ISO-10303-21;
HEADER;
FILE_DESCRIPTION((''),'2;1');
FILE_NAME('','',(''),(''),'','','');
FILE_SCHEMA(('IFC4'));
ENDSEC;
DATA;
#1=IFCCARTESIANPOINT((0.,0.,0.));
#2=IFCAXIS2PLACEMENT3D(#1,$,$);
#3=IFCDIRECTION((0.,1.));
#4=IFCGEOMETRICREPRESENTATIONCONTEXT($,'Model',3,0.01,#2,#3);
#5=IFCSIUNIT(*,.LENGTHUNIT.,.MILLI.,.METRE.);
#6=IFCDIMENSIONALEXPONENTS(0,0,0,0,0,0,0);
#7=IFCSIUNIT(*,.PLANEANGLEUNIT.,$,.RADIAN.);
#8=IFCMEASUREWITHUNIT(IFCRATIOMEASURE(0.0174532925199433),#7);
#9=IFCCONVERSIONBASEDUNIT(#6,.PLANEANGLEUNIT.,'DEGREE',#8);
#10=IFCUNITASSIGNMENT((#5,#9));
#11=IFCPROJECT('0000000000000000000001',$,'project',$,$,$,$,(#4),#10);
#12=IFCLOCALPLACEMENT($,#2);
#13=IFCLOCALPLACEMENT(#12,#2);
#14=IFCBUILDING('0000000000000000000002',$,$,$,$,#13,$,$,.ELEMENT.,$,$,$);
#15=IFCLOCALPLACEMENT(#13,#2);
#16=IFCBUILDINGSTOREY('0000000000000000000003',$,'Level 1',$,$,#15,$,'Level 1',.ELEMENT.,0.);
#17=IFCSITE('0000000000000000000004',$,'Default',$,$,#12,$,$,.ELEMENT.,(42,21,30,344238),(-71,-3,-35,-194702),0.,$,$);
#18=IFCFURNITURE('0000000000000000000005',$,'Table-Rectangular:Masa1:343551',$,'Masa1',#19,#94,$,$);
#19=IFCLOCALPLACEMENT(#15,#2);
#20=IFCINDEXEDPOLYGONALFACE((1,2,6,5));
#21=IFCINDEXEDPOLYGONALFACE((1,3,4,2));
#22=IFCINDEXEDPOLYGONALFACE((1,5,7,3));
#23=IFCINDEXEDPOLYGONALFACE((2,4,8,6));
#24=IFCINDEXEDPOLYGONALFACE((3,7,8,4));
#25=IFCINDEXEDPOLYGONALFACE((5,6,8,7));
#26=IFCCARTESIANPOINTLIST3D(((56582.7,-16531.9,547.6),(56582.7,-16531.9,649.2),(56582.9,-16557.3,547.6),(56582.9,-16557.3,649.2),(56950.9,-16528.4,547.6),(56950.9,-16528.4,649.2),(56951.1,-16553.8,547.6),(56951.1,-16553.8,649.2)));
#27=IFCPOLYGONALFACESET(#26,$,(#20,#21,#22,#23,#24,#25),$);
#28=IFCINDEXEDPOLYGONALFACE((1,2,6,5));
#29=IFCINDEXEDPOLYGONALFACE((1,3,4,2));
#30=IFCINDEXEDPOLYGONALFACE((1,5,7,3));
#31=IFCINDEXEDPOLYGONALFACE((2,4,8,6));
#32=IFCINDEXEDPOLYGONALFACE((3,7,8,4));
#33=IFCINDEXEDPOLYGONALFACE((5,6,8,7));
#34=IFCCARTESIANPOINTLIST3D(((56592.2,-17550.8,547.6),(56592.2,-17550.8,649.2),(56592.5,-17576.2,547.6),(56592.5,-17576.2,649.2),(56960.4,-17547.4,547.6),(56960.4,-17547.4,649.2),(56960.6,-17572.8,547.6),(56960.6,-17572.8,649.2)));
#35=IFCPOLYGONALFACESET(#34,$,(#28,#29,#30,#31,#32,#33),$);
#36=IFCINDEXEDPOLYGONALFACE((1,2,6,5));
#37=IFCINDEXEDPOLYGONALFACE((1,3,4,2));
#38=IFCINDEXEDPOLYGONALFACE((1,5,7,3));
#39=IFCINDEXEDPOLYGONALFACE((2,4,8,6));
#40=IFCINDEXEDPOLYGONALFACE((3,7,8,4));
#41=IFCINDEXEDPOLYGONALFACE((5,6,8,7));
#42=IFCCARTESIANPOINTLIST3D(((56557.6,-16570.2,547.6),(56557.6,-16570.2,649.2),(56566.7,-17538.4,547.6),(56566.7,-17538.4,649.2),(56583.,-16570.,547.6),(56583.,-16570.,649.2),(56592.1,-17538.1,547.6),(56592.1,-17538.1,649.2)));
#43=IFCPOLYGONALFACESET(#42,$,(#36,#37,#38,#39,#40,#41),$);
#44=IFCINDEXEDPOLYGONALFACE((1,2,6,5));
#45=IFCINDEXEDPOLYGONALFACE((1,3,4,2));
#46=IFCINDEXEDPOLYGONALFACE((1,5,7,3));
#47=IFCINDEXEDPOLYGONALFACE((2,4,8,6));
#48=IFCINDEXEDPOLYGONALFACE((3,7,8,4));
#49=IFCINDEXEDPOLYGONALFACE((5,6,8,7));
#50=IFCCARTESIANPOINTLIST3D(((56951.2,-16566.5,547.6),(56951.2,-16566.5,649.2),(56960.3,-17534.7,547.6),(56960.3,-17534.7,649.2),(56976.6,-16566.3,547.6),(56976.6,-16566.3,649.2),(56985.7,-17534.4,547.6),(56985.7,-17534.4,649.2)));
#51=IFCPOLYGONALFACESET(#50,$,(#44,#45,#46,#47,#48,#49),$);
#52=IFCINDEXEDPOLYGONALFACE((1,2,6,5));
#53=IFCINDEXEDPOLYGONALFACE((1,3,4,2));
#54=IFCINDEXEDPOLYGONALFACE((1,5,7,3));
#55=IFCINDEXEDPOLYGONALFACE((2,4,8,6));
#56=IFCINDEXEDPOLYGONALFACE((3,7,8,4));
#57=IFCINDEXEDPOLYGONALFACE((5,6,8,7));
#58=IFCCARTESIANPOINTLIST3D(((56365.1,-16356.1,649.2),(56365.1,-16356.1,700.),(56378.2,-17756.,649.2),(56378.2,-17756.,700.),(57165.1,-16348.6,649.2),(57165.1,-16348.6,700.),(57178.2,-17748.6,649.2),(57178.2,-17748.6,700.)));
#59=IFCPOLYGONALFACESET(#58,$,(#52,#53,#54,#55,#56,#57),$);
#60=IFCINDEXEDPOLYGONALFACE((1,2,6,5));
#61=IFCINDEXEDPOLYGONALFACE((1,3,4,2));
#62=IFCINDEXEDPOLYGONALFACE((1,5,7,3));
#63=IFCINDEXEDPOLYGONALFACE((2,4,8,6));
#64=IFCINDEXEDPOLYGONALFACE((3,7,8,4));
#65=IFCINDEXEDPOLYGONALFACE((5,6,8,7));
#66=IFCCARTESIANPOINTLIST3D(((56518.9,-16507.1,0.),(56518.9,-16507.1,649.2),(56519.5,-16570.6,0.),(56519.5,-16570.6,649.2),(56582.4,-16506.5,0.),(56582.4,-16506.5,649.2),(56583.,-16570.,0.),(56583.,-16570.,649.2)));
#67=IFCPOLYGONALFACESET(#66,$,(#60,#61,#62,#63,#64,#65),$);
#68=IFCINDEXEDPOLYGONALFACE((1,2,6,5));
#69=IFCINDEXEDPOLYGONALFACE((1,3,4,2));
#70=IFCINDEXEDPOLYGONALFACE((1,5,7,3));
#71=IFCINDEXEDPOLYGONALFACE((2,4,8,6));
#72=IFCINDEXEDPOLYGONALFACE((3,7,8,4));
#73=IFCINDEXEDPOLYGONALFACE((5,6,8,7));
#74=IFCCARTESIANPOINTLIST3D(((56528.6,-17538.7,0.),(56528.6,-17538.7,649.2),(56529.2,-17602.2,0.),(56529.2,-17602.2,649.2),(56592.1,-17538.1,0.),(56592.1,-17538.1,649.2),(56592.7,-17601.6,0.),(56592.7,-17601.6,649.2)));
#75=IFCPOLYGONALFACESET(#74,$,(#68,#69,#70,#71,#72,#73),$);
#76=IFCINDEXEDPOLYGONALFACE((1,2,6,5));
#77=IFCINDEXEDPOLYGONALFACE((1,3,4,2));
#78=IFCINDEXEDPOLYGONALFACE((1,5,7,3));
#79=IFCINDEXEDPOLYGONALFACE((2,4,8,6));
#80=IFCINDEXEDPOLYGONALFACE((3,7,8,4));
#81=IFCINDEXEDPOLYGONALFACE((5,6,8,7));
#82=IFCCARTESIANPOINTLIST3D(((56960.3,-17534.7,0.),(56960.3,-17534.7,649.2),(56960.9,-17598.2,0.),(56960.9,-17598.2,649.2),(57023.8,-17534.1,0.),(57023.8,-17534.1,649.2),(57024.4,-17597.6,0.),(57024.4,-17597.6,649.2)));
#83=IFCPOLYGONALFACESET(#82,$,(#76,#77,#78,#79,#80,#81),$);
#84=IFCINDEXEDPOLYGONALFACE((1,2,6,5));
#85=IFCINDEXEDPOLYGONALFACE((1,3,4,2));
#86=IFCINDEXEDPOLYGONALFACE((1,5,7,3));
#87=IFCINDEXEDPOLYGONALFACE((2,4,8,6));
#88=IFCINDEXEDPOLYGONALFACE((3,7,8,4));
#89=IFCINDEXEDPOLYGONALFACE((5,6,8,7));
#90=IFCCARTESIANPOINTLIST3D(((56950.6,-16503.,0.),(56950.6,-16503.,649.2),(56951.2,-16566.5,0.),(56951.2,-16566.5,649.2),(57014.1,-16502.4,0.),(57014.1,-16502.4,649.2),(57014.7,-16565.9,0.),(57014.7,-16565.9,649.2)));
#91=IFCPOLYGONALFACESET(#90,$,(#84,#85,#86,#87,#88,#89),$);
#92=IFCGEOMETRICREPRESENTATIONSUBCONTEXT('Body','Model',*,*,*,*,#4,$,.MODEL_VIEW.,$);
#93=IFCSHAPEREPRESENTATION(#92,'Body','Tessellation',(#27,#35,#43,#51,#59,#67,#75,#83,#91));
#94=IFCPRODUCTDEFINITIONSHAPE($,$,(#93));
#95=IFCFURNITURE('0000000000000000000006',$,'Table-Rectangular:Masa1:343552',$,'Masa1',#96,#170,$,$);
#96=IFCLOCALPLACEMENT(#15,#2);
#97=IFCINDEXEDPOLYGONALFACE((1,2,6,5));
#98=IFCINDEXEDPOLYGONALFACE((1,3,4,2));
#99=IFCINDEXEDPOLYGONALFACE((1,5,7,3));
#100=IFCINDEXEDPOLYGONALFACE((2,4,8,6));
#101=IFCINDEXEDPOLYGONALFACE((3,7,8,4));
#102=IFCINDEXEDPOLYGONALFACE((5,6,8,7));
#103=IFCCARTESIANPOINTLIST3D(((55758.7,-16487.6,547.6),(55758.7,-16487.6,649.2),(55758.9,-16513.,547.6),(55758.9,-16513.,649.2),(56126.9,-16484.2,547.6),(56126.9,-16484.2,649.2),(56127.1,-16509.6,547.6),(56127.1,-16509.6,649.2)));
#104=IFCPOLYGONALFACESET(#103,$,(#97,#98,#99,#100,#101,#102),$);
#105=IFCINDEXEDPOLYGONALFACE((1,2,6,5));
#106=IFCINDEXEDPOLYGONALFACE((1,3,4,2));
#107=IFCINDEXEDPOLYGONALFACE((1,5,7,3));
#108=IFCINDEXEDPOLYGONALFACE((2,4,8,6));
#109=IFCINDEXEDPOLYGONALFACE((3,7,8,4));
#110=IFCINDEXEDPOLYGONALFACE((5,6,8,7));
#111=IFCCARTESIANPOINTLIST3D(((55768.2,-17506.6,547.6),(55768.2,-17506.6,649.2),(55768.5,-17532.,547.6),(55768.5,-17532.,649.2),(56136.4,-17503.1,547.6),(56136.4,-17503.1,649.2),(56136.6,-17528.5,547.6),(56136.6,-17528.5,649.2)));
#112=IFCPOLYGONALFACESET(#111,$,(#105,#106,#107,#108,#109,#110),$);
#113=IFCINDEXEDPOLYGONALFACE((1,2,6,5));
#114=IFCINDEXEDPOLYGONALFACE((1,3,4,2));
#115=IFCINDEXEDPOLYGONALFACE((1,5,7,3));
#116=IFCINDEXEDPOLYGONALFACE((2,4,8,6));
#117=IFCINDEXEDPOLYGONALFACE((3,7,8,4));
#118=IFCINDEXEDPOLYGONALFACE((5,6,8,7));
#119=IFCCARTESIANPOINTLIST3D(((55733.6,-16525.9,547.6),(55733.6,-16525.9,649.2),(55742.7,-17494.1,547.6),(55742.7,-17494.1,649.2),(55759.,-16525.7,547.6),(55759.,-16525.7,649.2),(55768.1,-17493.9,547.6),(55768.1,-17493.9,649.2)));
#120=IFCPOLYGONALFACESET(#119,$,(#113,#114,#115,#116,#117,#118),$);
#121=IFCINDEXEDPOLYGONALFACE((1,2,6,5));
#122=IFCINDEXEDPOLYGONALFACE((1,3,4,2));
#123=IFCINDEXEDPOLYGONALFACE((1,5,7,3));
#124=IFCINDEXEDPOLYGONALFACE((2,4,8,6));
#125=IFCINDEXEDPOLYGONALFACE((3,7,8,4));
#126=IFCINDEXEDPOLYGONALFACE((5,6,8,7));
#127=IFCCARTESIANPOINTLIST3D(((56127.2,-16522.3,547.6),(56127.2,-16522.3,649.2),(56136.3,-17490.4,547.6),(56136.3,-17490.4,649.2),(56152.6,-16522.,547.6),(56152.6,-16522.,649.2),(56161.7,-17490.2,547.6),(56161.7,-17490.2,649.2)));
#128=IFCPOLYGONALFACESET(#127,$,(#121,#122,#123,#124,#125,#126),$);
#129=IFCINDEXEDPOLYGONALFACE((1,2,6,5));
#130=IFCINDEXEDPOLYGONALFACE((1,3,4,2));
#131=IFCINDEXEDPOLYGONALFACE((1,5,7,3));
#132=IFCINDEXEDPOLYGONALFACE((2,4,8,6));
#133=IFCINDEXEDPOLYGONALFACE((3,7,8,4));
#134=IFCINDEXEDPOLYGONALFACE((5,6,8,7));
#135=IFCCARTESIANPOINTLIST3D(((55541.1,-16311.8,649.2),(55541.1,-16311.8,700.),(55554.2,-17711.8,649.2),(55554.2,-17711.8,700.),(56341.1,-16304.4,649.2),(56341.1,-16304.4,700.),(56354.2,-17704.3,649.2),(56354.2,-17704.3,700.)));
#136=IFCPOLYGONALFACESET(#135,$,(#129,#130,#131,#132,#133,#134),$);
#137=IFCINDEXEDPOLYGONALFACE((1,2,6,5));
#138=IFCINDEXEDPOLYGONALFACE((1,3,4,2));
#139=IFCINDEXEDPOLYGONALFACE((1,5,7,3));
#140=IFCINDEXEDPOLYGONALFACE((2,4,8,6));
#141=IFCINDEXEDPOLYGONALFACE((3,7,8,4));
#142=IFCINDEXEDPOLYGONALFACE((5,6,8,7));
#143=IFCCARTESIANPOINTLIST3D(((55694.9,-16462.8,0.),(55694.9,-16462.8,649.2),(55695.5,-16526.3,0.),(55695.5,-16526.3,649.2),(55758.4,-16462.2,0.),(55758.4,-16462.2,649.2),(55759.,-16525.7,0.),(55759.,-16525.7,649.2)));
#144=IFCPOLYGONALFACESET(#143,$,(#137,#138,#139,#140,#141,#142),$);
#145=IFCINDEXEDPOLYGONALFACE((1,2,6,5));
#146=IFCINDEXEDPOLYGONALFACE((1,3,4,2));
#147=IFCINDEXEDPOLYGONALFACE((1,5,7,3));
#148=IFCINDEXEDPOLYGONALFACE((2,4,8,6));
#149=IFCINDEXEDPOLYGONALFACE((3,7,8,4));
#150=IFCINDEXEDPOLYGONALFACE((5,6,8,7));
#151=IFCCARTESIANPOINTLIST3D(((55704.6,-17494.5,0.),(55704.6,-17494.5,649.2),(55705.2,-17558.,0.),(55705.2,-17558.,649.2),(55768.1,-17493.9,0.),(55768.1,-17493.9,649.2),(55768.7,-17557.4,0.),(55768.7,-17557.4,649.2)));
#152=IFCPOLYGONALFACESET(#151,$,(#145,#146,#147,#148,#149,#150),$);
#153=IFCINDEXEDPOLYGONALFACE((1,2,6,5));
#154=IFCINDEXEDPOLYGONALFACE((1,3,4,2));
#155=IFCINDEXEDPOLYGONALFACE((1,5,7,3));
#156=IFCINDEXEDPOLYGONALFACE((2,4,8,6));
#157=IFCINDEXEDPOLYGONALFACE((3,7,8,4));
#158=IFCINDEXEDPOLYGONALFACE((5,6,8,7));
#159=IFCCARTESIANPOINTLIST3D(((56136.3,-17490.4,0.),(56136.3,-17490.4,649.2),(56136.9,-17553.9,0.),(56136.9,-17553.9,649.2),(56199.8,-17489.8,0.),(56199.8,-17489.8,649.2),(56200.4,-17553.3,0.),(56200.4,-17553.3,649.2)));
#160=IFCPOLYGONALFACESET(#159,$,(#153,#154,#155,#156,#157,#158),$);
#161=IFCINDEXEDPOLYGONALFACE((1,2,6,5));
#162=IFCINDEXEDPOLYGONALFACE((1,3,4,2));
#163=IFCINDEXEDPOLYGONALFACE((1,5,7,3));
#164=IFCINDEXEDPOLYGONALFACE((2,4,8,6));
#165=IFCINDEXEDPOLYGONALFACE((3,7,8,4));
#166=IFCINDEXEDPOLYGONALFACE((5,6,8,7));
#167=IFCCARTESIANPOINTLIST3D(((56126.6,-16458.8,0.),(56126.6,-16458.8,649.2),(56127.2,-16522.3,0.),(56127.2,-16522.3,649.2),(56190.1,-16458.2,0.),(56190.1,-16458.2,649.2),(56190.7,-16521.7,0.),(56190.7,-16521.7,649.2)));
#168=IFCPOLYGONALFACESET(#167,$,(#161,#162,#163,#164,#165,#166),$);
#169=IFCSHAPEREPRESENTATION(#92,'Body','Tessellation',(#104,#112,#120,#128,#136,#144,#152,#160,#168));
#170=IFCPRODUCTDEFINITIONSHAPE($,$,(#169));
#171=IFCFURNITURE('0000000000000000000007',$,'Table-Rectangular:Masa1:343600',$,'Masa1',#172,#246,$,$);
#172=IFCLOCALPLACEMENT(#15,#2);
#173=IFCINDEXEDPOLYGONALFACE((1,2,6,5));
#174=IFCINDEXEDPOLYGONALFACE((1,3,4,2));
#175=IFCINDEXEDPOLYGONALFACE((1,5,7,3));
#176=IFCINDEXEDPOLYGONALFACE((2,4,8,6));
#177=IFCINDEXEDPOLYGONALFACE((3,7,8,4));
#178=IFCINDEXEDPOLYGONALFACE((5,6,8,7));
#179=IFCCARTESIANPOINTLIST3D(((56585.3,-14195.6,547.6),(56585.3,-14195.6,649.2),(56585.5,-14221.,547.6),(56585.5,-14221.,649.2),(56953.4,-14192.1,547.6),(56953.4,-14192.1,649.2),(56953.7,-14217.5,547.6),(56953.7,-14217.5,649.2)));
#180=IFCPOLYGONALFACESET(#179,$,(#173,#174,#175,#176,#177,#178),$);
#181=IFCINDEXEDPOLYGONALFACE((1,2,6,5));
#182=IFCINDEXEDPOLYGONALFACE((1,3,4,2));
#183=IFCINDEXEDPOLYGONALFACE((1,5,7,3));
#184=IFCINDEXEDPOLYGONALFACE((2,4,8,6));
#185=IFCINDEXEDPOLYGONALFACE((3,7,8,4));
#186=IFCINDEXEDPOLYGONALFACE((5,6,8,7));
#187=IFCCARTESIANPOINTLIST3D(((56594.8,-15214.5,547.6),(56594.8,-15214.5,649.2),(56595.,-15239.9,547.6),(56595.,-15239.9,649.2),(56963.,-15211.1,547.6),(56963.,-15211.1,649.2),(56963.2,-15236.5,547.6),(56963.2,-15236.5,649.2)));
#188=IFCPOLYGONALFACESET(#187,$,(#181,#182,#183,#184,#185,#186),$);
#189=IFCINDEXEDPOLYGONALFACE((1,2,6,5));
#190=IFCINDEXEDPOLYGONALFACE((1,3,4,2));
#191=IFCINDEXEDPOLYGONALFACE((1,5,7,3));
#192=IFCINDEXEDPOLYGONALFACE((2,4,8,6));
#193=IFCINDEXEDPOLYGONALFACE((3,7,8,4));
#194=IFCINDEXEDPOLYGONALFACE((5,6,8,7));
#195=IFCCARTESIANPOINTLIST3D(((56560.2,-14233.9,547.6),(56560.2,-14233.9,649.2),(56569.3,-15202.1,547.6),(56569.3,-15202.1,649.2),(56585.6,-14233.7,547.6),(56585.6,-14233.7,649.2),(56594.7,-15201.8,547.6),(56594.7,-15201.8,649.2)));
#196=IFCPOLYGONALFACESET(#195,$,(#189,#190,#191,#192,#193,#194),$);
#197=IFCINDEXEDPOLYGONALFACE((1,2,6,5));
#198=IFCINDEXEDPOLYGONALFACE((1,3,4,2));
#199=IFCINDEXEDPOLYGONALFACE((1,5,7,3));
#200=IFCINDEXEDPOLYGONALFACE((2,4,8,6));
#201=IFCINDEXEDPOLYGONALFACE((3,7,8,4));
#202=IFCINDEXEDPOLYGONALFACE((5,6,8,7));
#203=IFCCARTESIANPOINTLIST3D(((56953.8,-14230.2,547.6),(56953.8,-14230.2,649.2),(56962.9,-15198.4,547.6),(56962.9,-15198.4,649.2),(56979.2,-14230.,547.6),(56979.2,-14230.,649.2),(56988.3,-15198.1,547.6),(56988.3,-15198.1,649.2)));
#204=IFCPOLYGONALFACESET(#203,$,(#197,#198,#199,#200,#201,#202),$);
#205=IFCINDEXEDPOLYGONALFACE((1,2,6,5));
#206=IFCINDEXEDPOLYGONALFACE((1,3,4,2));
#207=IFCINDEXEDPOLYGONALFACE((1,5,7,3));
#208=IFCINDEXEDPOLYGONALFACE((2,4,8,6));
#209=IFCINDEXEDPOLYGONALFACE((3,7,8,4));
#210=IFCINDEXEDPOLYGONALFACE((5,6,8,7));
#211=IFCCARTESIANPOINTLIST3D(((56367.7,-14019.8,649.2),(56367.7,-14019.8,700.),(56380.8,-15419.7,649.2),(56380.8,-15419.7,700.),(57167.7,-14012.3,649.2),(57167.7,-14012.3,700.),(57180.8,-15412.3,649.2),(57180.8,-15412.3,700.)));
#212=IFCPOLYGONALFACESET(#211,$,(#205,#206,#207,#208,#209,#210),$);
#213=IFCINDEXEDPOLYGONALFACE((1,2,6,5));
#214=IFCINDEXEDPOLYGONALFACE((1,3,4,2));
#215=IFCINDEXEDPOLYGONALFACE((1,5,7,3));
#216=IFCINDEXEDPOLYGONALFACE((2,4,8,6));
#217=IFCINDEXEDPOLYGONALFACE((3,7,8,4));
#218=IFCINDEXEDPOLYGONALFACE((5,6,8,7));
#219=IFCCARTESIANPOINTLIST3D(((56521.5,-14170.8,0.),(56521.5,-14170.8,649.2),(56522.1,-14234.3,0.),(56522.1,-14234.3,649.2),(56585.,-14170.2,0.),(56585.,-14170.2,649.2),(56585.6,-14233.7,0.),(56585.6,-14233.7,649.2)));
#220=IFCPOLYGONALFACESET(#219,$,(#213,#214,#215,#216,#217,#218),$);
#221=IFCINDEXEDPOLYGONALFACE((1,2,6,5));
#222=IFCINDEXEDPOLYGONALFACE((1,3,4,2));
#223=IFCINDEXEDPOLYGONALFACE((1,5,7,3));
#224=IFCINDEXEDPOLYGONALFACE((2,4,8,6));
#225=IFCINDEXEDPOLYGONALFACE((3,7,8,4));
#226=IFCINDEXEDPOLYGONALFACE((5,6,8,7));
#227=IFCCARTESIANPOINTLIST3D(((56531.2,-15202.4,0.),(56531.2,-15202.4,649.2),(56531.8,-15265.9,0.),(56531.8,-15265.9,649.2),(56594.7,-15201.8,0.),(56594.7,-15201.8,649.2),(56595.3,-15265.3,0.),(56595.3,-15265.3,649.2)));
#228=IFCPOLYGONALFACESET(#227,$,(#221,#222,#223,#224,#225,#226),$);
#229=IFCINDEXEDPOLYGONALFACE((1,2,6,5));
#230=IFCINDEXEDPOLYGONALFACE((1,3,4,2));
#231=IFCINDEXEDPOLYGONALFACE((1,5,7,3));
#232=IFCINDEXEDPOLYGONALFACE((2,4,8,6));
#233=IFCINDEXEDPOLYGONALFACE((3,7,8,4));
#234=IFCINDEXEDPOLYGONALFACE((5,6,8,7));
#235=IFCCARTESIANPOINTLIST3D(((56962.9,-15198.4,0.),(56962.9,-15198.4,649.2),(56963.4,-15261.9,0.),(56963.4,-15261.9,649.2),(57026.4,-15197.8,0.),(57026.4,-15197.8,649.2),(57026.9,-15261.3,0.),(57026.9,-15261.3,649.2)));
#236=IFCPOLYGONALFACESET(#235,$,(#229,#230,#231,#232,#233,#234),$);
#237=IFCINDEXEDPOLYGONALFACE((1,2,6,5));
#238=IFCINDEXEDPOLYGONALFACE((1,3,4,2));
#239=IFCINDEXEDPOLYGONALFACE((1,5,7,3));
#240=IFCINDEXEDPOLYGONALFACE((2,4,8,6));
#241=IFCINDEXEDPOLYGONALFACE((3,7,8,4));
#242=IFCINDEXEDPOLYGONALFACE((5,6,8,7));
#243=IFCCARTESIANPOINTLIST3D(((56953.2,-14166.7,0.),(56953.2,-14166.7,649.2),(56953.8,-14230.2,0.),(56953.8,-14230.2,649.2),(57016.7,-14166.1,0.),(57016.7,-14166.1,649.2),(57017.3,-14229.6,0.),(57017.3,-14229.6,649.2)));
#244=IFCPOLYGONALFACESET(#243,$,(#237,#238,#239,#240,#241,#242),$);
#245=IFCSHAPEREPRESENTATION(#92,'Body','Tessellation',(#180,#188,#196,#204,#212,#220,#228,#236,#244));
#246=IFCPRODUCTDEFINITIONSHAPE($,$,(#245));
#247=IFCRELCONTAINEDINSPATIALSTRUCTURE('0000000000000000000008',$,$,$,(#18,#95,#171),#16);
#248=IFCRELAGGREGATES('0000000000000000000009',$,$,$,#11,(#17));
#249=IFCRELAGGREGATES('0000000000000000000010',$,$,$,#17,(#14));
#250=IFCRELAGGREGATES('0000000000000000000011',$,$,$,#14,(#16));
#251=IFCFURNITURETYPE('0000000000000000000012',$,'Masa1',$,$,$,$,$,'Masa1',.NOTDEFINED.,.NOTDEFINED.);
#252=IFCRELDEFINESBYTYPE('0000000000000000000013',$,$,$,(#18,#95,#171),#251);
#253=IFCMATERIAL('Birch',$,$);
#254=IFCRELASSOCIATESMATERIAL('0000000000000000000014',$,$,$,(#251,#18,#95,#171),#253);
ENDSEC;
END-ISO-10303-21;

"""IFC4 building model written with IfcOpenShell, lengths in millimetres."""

from ifc_helpers import new_model, entity, si_unit, converted_unit, direction, frame, frame_2d, origin, origin_2d_with_axis, place, context, subcontext, project, spatial, rectangle, extrude, source, transform, mapped, material, type_object, type_shapes, element, save


model = new_model("IFC4")

# Units and contexts
model_context = context("Model", 3, precision=0.01, world=origin(), true_north=direction((0.0, 1.0)))
body_context = subcontext(model_context, "Body", "Model", "MODEL_VIEW")
ifc_project = project(units=[si_unit("LENGTHUNIT", "METRE", prefix="MILLI"), converted_unit("PLANEANGLEUNIT", "DEGREE", entity("IfcRatioMeasure", 0.0174532925199433), si_unit("PLANEANGLEUNIT", "RADIAN"), dimensions=[0, 0, 0, 0, 0, 0, 0])], contexts=[model_context])

# Site, building, storey
site_placement = place(None, origin())
site = spatial("IfcSite", under=ifc_project, at=site_placement, Name="Default", CompositionType="ELEMENT", RefLatitude=(42, 21, 30, 344238), RefLongitude=(-71, -3, -35, -194702), RefElevation=0.0)
building_placement = place(site_placement, origin())
building = spatial("IfcBuilding", under=site, at=building_placement, CompositionType="ELEMENT")
storey_placement = place(building_placement, origin())
storey = spatial("IfcBuildingStorey", under=building, at=storey_placement, Name="Level 1", LongName="Level 1", CompositionType="ELEMENT", Elevation=0.0)

# Furniture
ifc_material_1 = material(Name="Birch")
furniture_type_1 = type_object("IfcFurnitureType", Name="Masa1", ElementType="Masa1", AssemblyPlace="NOTDEFINED", PredefinedType="NOTDEFINED", material=ifc_material_1)
shared_shape_1 = source(origin(), body_context, "Body", "SweptSolid", [
    extrude(rectangle(XDim=25.4, YDim=368.2, at=origin_2d_with_axis()), frame((509.5, 0.0, 547.6)), (0.0, 0.0, 1.0), 101.6),
    extrude(rectangle(XDim=368.2, YDim=25.4, at=origin_2d_with_axis()), frame((-509.5, 0.0, 547.6), z_axis=(0.0, 0.0, 1.0), x_axis=(0.0, 1.0, 0.0)), (0.0, 0.0, 1.0), 101.6),
    extrude(rectangle(XDim=968.2, YDim=25.4, at=frame_2d((0.0, 0.0), x_axis=(1.0, 0.0))), frame((0.0, 196.8, 547.6), z_axis=(0.0, 0.0, 1.0), x_axis=(-1.0, 0.0, 0.0)), (0.0, 0.0, 1.0), 101.6),
    extrude(rectangle(XDim=25.4, YDim=968.2, at=origin_2d_with_axis()), frame((0.0, -196.8, 547.6), z_axis=(0.0, 0.0, 1.0), x_axis=(0.0, 1.0, 0.0)), (0.0, 0.0, 1.0), 101.6),
    extrude(rectangle(XDim=1400.0, YDim=800.0, at=origin_2d_with_axis()), frame((0.0, 0.0, 649.2), z_axis=(0.0, 0.0, 1.0), x_axis=(-1.0, 0.0, 0.0)), (0.0, 0.0, 1.0), 50.8),
    extrude(rectangle(XDim=63.5, YDim=63.5, at=origin_2d_with_axis()), frame((515.9, 215.9, 0.0), z_axis=(0.0, 0.0, 1.0), x_axis=(0.0, -1.0, 0.0)), (0.0, 0.0, 1.0), 649.2),
    extrude(rectangle(XDim=63.5, YDim=63.5, at=origin_2d_with_axis()), frame((-515.9, 215.9, 0.0), z_axis=(0.0, 0.0, 1.0), x_axis=(-1.0, 0.0, 0.0)), (0.0, 0.0, 1.0), 649.2),
    extrude(rectangle(XDim=63.5, YDim=63.5, at=origin_2d_with_axis()), frame((-515.9, -215.9, 0.0), z_axis=(0.0, 0.0, 1.0), x_axis=(0.0, 1.0, 0.0)), (0.0, 0.0, 1.0), 649.2),
    extrude(rectangle(XDim=63.5, YDim=63.5, at=frame_2d((0.0, 0.0), x_axis=(1.0, 0.0))), frame((515.9, -215.9, 0.0)), (0.0, 0.0, 1.0), 649.2),
])
type_shapes(furniture_type_1, [shared_shape_1])
for number, where, z_axis, x_axis, name in (
    (1, (56771.7, -17052.3, 0.0), (0.0, 0.0, 1.0), (-0.009355, 0.999956, 0.0), "Table-Rectangular:Masa1:343551"),
    (2, (55947.7, -17008.1, 0.0), (0.0, 0.0, 1.0), (-0.009355, 0.999956, 0.0), "Table-Rectangular:Masa1:343552"),
    (3, (56774.2, -14716.0, 0.0), (0.0, 0.0, 1.0), (-0.009355, 0.999956, 0.0), "Table-Rectangular:Masa1:343600"),
):
    element("IfcFurniture", number, at=place(storey_placement, frame(where, z_axis=z_axis, x_axis=x_axis)), inside=storey, type_object=furniture_type_1, material=ifc_material_1, Name=name, ObjectType="Masa1", context=body_context, shape_type="MappedRepresentation", body=[
        mapped(shared_shape_1, transform((0.0, 0.0, 0.0), scale=1.0)),
    ])

save(model, "model.ifc")
